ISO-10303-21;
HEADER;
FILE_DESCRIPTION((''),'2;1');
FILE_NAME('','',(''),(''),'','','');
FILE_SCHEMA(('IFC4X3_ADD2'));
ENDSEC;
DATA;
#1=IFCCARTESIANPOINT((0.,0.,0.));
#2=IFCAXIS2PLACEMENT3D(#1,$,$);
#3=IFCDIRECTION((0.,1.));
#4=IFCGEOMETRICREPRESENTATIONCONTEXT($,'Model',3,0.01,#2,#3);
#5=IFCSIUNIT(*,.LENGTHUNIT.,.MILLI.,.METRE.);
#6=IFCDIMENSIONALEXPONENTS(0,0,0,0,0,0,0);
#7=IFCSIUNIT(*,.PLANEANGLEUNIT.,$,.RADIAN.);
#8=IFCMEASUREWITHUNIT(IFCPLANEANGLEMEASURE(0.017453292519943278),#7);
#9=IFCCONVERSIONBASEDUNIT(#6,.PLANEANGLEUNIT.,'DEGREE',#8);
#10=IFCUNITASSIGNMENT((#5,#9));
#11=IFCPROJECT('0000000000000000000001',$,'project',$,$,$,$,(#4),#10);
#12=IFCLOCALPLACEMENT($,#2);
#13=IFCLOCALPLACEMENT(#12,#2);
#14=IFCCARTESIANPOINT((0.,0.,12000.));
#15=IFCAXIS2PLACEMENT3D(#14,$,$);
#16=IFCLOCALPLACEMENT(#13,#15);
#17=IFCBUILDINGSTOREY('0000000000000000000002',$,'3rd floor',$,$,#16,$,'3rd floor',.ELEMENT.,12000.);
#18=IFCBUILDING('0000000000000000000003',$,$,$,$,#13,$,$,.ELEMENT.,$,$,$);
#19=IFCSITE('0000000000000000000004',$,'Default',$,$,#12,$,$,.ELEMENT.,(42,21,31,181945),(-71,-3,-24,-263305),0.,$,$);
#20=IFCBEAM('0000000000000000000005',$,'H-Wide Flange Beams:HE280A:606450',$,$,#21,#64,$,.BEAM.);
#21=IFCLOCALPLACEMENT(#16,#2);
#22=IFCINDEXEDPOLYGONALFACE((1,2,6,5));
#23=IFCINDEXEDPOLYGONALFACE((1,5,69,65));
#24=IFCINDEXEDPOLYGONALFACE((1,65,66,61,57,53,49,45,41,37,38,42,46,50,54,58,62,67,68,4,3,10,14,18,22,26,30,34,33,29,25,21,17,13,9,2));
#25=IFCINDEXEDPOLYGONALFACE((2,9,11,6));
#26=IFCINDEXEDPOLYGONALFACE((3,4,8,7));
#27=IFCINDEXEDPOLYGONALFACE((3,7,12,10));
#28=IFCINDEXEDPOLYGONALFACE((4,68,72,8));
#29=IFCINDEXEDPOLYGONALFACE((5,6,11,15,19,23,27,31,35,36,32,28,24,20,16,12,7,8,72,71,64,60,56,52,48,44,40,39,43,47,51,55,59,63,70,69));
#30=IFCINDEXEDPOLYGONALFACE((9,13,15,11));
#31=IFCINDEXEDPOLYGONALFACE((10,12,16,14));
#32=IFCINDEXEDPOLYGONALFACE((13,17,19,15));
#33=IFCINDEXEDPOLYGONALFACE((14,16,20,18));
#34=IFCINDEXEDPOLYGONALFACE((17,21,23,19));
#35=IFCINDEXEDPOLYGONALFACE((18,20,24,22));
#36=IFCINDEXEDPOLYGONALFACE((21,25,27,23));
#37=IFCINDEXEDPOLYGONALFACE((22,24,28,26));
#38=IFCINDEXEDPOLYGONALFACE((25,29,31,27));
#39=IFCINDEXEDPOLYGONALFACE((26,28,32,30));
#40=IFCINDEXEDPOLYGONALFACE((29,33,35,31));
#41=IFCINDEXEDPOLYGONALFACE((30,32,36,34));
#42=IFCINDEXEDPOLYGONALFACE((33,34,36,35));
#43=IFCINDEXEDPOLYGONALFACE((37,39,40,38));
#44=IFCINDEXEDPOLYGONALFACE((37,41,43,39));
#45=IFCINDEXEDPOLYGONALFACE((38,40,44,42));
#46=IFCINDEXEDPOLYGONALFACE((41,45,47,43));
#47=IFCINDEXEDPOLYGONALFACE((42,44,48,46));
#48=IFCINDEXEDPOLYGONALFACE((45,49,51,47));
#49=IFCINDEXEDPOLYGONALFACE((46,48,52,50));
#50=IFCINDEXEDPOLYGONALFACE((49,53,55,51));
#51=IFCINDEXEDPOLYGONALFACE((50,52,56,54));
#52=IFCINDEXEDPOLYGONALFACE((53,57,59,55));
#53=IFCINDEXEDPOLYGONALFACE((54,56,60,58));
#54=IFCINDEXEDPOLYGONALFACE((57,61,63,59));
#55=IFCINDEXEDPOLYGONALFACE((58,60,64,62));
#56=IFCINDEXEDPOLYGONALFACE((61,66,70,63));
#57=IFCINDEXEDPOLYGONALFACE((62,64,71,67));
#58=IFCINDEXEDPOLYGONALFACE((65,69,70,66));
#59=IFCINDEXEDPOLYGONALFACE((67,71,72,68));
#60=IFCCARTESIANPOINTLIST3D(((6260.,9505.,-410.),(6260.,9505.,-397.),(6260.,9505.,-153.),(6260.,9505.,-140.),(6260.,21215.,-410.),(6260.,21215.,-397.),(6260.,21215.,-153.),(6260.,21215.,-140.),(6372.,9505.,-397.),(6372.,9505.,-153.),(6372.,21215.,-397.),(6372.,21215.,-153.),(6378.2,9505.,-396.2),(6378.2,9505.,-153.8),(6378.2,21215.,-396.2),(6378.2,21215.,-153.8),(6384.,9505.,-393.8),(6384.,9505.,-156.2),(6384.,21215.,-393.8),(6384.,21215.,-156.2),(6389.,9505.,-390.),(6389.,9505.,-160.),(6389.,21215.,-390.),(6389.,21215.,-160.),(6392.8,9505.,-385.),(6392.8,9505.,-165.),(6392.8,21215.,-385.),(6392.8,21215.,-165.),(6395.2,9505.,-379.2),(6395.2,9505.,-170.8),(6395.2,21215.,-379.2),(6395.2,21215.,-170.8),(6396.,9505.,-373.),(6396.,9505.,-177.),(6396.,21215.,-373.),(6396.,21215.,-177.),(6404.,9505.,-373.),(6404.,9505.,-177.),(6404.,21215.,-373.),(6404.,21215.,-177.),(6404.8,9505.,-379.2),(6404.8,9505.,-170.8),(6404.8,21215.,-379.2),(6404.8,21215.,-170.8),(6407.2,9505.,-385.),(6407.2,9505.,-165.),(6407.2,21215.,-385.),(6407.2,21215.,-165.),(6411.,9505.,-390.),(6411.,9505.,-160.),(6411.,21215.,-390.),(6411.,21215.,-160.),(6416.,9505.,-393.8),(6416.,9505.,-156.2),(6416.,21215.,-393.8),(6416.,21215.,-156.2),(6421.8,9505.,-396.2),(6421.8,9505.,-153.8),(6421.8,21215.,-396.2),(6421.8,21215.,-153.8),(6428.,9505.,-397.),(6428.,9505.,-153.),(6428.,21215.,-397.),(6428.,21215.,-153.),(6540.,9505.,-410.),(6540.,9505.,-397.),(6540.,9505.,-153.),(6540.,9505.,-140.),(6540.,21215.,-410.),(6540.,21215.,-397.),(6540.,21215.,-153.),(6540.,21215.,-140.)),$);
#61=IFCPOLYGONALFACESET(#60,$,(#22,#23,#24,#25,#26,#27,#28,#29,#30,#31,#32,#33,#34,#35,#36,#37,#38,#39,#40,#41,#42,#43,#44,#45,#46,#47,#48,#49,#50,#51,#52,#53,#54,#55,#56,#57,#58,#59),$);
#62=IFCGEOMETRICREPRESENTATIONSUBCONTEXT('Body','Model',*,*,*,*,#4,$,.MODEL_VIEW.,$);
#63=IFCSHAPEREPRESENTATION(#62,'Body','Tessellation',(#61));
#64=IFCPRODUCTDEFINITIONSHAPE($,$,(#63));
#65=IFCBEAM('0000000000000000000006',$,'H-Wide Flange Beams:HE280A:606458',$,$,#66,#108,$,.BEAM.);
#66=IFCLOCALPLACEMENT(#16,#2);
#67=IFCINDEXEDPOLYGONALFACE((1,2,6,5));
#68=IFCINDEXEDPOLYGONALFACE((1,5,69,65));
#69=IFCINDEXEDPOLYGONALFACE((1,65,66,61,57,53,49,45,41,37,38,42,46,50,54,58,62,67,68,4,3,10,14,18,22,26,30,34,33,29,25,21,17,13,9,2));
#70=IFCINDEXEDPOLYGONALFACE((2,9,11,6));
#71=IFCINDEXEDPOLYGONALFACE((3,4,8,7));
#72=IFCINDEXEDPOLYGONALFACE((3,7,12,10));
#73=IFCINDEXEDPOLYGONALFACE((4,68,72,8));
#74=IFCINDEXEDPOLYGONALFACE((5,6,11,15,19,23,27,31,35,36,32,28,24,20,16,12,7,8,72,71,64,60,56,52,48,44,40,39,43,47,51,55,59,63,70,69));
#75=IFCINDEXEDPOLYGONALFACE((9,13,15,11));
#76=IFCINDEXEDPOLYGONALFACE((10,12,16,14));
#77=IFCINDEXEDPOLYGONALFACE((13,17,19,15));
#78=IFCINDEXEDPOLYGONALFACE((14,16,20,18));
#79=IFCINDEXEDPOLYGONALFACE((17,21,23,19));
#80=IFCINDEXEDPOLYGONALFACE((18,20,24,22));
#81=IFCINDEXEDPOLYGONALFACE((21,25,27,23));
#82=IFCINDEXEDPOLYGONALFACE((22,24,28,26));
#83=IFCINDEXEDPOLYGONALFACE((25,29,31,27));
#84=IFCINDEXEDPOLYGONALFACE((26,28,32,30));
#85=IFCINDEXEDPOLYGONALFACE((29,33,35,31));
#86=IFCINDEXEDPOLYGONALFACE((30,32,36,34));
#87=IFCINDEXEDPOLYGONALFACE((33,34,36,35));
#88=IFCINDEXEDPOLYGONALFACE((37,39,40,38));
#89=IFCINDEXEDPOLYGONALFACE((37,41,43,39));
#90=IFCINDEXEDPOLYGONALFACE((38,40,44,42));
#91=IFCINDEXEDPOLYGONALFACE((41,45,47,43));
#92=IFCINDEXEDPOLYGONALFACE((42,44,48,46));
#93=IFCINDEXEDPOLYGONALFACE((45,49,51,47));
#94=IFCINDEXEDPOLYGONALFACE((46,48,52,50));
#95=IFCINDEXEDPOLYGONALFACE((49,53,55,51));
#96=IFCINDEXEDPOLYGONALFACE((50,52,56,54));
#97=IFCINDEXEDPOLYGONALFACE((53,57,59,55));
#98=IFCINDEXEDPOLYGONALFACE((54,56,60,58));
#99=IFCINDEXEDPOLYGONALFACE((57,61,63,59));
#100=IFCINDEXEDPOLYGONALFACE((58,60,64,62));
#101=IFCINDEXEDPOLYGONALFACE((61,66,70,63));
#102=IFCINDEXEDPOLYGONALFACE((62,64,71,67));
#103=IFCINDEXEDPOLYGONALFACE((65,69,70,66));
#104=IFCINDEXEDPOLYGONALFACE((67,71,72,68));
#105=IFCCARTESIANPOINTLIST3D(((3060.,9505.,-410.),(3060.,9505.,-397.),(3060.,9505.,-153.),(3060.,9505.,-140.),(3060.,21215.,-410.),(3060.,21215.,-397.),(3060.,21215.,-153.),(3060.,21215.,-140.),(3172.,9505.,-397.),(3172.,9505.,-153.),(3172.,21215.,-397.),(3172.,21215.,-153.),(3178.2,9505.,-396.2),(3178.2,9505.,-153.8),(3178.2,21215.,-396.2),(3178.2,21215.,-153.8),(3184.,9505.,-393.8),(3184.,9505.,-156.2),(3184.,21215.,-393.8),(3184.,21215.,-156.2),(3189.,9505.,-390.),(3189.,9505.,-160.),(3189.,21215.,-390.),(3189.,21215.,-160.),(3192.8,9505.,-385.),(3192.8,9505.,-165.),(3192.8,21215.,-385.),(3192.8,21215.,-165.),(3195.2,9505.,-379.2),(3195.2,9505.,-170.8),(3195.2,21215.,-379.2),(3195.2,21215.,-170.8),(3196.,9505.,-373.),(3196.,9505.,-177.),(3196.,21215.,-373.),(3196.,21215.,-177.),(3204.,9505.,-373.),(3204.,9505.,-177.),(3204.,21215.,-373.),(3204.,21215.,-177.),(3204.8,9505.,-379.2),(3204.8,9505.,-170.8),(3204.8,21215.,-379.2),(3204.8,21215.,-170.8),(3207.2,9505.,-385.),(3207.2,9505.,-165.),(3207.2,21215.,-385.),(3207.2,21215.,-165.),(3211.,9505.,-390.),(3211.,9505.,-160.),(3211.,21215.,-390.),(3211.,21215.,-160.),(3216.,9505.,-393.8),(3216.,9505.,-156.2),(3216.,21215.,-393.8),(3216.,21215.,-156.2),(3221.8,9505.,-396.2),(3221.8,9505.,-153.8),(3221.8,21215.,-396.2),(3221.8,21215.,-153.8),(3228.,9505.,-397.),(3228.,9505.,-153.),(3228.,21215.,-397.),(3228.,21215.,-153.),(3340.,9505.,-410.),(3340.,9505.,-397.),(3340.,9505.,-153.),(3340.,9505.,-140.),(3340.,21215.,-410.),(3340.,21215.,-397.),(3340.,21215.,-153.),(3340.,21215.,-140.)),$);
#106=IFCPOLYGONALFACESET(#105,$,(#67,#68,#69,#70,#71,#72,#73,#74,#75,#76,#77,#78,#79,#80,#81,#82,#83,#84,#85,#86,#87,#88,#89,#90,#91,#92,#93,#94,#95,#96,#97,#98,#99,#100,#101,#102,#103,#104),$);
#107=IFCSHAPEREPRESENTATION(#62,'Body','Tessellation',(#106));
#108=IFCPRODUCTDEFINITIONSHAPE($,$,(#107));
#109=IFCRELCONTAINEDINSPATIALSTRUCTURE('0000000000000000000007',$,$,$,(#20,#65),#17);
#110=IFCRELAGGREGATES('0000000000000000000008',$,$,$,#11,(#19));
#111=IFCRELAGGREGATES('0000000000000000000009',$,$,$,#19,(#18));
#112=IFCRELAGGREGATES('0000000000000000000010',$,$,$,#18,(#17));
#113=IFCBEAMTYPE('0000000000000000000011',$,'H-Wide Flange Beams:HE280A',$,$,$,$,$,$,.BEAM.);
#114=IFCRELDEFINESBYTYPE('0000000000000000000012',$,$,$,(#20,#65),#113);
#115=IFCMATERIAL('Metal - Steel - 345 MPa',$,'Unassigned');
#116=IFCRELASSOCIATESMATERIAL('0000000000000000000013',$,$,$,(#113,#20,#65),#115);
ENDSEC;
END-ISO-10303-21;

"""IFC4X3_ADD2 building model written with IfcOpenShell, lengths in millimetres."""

from ifc_helpers import new_model, entity, si_unit, converted_unit, direction, frame, frame_2d, origin, place, context, subcontext, project, spatial, polyline, circle_curve, parameter, trimmed, segment, composite_curve, outline, extrude, source, transform, mapped, material, material_profile, profile_set, profile_usage, type_object, type_shapes, element, save


model = new_model("IFC4X3_ADD2")

# Units and contexts
model_context = context("Model", 3, precision=0.01, world=origin(), true_north=direction((0.0, 1.0)))
body_context = subcontext(model_context, "Body", "Model", "MODEL_VIEW")
ifc_project = project(units=[si_unit("LENGTHUNIT", "METRE", prefix="MILLI"), converted_unit("PLANEANGLEUNIT", "DEGREE", entity("IfcPlaneAngleMeasure", 0.017453292519943278), si_unit("PLANEANGLEUNIT", "RADIAN"), dimensions=[0, 0, 0, 0, 0, 0, 0])], contexts=[model_context])

# Site, building, storey
site_placement = place(None, origin())
site = spatial("IfcSite", under=ifc_project, at=site_placement, Name="Default", CompositionType="ELEMENT", RefLatitude=(42, 21, 31, 181945), RefLongitude=(-71, -3, -24, -263305), RefElevation=0.0)
building_placement = place(site_placement, origin())
building = spatial("IfcBuilding", under=site, at=building_placement, CompositionType="ELEMENT")
storey_placement = place(building_placement, frame((0.0, 0.0, 12000.0)))
storey = spatial("IfcBuildingStorey", under=building, at=storey_placement, Name="3rd floor", LongName="3rd floor", CompositionType="ELEMENT", Elevation=12000.0)

# Beams
ifc_material_1 = material(Name="Metal - Steel - 345 MPa", Category="Unassigned")
ifc_material_profile_1 = material_profile(ifc_material_1, outline(composite_curve([segment(polyline([(-140.0, -122.0), (-140.0, -135.0)]), True, "CONTINUOUS"), segment(polyline([(-140.0, -135.0), (140.0, -135.0)]), True, "CONTINUOUS"), segment(polyline([(140.0, -135.0), (140.0, -122.0)]), True, "CONTINUOUS"), segment(polyline([(140.0, -122.0), (28.0, -122.0)]), True, "CONTINUOUS"), segment(trimmed(circle_curve(frame_2d((28.0, -98.0), x_axis=(1.0, 0.0)), 24.0), [parameter(180.0)], [parameter(270.0)], True, "PARAMETER"), False, "CONTINUOUS"), segment(polyline([(4.0, -98.0), (4.0, 98.0)]), True, "CONTINUOUS"), segment(trimmed(circle_curve(frame_2d((28.0, 98.0), x_axis=(1.0, 0.0)), 24.0), [parameter(90.0)], [parameter(180.0)], True, "PARAMETER"), False, "CONTINUOUS"), segment(polyline([(28.0, 122.0), (140.0, 122.0)]), True, "CONTINUOUS"), segment(polyline([(140.0, 122.0), (140.0, 135.0)]), True, "CONTINUOUS"), segment(polyline([(140.0, 135.0), (-140.0, 135.0)]), True, "CONTINUOUS"), segment(polyline([(-140.0, 135.0), (-140.0, 122.0)]), True, "CONTINUOUS"), segment(polyline([(-140.0, 122.0), (-28.0, 122.0)]), True, "CONTINUOUS"), segment(trimmed(circle_curve(frame_2d((-28.0, 98.0), x_axis=(1.0, 0.0)), 24.0), [parameter(360.0)], [parameter(90.0)], True, "PARAMETER"), False, "CONTINUOUS"), segment(polyline([(-4.0, 98.0), (-4.0, -98.0)]), True, "CONTINUOUS"), segment(trimmed(circle_curve(frame_2d((-28.0, -98.0), x_axis=(1.0, 0.0)), 24.0), [parameter(270.0)], [parameter(360.0)], True, "PARAMETER"), False, "CONTINUOUS"), segment(polyline([(-28.0, -122.0), (-140.0, -122.0)]), True, "CONTINUOUS")], self_intersect=False)), Name="HE280A")
ifc_profile_set_1 = profile_set([ifc_material_profile_1], Name="HE280A")
ifc_profile_usage_1 = profile_usage(ifc_profile_set_1, cardinal=8)
beam_type_1 = type_object("IfcBeamType", Name="H-Wide Flange Beams:HE280A", PredefinedType="BEAM", material=ifc_profile_set_1)
shared_shape_1 = source(origin(), body_context, "Body", "SweptSolid", [
    extrude(outline(composite_curve([segment(polyline([(-140.0, -122.0), (-140.0, -135.0)]), True, "CONTINUOUS"), segment(polyline([(-140.0, -135.0), (140.0, -135.0)]), True, "CONTINUOUS"), segment(polyline([(140.0, -135.0), (140.0, -122.0)]), True, "CONTINUOUS"), segment(polyline([(140.0, -122.0), (28.0, -122.0)]), True, "CONTINUOUS"), segment(trimmed(circle_curve(frame_2d((28.0, -98.0), x_axis=(1.0, 0.0)), 24.0), [parameter(180.0)], [parameter(270.0)], True, "PARAMETER"), False, "CONTINUOUS"), segment(polyline([(4.0, -98.0), (4.0, 98.0)]), True, "CONTINUOUS"), segment(trimmed(circle_curve(frame_2d((28.0, 98.0), x_axis=(1.0, 0.0)), 24.0), [parameter(90.0)], [parameter(180.0)], True, "PARAMETER"), False, "CONTINUOUS"), segment(polyline([(28.0, 122.0), (140.0, 122.0)]), True, "CONTINUOUS"), segment(polyline([(140.0, 122.0), (140.0, 135.0)]), True, "CONTINUOUS"), segment(polyline([(140.0, 135.0), (-140.0, 135.0)]), True, "CONTINUOUS"), segment(polyline([(-140.0, 135.0), (-140.0, 122.0)]), True, "CONTINUOUS"), segment(polyline([(-140.0, 122.0), (-28.0, 122.0)]), True, "CONTINUOUS"), segment(trimmed(circle_curve(frame_2d((-28.0, 98.0), x_axis=(1.0, 0.0)), 24.0), [parameter(360.0)], [parameter(90.0)], True, "PARAMETER"), False, "CONTINUOUS"), segment(polyline([(-4.0, 98.0), (-4.0, -98.0)]), True, "CONTINUOUS"), segment(trimmed(circle_curve(frame_2d((-28.0, -98.0), x_axis=(1.0, 0.0)), 24.0), [parameter(270.0)], [parameter(360.0)], True, "PARAMETER"), False, "CONTINUOUS"), segment(polyline([(-28.0, -122.0), (-140.0, -122.0)]), True, "CONTINUOUS")], self_intersect=False)), frame((-4255.0, 0.0, 0.0), z_axis=(-1.0, 0.0, 0.0), x_axis=(0.0, -1.0, 0.0)), (0.0, 0.0, -1.0), 11710.0),
])
type_shapes(beam_type_1, [shared_shape_1])
for number, where, z_axis, x_axis, name in (
    (1, (6400.0, 16960.0, -275.0), (0.0, 0.0, 1.0), (0.0, -1.0, 0.0), "H-Wide Flange Beams:HE280A:606450"),
    (2, (3200.0, 16960.0, -275.0), (0.0, 0.0, 1.0), (0.0, -1.0, 0.0), "H-Wide Flange Beams:HE280A:606458"),
):
    element("IfcBeam", number, at=place(storey_placement, frame(where, z_axis=z_axis, x_axis=x_axis)), inside=storey, type_object=beam_type_1, material=ifc_profile_usage_1, Name=name, PredefinedType="BEAM", context=body_context, shape_type="MappedRepresentation", body=[
        mapped(shared_shape_1, transform((0.0, 0.0, 0.0), scale=1.0)),
    ])

save(model, "model.ifc")
